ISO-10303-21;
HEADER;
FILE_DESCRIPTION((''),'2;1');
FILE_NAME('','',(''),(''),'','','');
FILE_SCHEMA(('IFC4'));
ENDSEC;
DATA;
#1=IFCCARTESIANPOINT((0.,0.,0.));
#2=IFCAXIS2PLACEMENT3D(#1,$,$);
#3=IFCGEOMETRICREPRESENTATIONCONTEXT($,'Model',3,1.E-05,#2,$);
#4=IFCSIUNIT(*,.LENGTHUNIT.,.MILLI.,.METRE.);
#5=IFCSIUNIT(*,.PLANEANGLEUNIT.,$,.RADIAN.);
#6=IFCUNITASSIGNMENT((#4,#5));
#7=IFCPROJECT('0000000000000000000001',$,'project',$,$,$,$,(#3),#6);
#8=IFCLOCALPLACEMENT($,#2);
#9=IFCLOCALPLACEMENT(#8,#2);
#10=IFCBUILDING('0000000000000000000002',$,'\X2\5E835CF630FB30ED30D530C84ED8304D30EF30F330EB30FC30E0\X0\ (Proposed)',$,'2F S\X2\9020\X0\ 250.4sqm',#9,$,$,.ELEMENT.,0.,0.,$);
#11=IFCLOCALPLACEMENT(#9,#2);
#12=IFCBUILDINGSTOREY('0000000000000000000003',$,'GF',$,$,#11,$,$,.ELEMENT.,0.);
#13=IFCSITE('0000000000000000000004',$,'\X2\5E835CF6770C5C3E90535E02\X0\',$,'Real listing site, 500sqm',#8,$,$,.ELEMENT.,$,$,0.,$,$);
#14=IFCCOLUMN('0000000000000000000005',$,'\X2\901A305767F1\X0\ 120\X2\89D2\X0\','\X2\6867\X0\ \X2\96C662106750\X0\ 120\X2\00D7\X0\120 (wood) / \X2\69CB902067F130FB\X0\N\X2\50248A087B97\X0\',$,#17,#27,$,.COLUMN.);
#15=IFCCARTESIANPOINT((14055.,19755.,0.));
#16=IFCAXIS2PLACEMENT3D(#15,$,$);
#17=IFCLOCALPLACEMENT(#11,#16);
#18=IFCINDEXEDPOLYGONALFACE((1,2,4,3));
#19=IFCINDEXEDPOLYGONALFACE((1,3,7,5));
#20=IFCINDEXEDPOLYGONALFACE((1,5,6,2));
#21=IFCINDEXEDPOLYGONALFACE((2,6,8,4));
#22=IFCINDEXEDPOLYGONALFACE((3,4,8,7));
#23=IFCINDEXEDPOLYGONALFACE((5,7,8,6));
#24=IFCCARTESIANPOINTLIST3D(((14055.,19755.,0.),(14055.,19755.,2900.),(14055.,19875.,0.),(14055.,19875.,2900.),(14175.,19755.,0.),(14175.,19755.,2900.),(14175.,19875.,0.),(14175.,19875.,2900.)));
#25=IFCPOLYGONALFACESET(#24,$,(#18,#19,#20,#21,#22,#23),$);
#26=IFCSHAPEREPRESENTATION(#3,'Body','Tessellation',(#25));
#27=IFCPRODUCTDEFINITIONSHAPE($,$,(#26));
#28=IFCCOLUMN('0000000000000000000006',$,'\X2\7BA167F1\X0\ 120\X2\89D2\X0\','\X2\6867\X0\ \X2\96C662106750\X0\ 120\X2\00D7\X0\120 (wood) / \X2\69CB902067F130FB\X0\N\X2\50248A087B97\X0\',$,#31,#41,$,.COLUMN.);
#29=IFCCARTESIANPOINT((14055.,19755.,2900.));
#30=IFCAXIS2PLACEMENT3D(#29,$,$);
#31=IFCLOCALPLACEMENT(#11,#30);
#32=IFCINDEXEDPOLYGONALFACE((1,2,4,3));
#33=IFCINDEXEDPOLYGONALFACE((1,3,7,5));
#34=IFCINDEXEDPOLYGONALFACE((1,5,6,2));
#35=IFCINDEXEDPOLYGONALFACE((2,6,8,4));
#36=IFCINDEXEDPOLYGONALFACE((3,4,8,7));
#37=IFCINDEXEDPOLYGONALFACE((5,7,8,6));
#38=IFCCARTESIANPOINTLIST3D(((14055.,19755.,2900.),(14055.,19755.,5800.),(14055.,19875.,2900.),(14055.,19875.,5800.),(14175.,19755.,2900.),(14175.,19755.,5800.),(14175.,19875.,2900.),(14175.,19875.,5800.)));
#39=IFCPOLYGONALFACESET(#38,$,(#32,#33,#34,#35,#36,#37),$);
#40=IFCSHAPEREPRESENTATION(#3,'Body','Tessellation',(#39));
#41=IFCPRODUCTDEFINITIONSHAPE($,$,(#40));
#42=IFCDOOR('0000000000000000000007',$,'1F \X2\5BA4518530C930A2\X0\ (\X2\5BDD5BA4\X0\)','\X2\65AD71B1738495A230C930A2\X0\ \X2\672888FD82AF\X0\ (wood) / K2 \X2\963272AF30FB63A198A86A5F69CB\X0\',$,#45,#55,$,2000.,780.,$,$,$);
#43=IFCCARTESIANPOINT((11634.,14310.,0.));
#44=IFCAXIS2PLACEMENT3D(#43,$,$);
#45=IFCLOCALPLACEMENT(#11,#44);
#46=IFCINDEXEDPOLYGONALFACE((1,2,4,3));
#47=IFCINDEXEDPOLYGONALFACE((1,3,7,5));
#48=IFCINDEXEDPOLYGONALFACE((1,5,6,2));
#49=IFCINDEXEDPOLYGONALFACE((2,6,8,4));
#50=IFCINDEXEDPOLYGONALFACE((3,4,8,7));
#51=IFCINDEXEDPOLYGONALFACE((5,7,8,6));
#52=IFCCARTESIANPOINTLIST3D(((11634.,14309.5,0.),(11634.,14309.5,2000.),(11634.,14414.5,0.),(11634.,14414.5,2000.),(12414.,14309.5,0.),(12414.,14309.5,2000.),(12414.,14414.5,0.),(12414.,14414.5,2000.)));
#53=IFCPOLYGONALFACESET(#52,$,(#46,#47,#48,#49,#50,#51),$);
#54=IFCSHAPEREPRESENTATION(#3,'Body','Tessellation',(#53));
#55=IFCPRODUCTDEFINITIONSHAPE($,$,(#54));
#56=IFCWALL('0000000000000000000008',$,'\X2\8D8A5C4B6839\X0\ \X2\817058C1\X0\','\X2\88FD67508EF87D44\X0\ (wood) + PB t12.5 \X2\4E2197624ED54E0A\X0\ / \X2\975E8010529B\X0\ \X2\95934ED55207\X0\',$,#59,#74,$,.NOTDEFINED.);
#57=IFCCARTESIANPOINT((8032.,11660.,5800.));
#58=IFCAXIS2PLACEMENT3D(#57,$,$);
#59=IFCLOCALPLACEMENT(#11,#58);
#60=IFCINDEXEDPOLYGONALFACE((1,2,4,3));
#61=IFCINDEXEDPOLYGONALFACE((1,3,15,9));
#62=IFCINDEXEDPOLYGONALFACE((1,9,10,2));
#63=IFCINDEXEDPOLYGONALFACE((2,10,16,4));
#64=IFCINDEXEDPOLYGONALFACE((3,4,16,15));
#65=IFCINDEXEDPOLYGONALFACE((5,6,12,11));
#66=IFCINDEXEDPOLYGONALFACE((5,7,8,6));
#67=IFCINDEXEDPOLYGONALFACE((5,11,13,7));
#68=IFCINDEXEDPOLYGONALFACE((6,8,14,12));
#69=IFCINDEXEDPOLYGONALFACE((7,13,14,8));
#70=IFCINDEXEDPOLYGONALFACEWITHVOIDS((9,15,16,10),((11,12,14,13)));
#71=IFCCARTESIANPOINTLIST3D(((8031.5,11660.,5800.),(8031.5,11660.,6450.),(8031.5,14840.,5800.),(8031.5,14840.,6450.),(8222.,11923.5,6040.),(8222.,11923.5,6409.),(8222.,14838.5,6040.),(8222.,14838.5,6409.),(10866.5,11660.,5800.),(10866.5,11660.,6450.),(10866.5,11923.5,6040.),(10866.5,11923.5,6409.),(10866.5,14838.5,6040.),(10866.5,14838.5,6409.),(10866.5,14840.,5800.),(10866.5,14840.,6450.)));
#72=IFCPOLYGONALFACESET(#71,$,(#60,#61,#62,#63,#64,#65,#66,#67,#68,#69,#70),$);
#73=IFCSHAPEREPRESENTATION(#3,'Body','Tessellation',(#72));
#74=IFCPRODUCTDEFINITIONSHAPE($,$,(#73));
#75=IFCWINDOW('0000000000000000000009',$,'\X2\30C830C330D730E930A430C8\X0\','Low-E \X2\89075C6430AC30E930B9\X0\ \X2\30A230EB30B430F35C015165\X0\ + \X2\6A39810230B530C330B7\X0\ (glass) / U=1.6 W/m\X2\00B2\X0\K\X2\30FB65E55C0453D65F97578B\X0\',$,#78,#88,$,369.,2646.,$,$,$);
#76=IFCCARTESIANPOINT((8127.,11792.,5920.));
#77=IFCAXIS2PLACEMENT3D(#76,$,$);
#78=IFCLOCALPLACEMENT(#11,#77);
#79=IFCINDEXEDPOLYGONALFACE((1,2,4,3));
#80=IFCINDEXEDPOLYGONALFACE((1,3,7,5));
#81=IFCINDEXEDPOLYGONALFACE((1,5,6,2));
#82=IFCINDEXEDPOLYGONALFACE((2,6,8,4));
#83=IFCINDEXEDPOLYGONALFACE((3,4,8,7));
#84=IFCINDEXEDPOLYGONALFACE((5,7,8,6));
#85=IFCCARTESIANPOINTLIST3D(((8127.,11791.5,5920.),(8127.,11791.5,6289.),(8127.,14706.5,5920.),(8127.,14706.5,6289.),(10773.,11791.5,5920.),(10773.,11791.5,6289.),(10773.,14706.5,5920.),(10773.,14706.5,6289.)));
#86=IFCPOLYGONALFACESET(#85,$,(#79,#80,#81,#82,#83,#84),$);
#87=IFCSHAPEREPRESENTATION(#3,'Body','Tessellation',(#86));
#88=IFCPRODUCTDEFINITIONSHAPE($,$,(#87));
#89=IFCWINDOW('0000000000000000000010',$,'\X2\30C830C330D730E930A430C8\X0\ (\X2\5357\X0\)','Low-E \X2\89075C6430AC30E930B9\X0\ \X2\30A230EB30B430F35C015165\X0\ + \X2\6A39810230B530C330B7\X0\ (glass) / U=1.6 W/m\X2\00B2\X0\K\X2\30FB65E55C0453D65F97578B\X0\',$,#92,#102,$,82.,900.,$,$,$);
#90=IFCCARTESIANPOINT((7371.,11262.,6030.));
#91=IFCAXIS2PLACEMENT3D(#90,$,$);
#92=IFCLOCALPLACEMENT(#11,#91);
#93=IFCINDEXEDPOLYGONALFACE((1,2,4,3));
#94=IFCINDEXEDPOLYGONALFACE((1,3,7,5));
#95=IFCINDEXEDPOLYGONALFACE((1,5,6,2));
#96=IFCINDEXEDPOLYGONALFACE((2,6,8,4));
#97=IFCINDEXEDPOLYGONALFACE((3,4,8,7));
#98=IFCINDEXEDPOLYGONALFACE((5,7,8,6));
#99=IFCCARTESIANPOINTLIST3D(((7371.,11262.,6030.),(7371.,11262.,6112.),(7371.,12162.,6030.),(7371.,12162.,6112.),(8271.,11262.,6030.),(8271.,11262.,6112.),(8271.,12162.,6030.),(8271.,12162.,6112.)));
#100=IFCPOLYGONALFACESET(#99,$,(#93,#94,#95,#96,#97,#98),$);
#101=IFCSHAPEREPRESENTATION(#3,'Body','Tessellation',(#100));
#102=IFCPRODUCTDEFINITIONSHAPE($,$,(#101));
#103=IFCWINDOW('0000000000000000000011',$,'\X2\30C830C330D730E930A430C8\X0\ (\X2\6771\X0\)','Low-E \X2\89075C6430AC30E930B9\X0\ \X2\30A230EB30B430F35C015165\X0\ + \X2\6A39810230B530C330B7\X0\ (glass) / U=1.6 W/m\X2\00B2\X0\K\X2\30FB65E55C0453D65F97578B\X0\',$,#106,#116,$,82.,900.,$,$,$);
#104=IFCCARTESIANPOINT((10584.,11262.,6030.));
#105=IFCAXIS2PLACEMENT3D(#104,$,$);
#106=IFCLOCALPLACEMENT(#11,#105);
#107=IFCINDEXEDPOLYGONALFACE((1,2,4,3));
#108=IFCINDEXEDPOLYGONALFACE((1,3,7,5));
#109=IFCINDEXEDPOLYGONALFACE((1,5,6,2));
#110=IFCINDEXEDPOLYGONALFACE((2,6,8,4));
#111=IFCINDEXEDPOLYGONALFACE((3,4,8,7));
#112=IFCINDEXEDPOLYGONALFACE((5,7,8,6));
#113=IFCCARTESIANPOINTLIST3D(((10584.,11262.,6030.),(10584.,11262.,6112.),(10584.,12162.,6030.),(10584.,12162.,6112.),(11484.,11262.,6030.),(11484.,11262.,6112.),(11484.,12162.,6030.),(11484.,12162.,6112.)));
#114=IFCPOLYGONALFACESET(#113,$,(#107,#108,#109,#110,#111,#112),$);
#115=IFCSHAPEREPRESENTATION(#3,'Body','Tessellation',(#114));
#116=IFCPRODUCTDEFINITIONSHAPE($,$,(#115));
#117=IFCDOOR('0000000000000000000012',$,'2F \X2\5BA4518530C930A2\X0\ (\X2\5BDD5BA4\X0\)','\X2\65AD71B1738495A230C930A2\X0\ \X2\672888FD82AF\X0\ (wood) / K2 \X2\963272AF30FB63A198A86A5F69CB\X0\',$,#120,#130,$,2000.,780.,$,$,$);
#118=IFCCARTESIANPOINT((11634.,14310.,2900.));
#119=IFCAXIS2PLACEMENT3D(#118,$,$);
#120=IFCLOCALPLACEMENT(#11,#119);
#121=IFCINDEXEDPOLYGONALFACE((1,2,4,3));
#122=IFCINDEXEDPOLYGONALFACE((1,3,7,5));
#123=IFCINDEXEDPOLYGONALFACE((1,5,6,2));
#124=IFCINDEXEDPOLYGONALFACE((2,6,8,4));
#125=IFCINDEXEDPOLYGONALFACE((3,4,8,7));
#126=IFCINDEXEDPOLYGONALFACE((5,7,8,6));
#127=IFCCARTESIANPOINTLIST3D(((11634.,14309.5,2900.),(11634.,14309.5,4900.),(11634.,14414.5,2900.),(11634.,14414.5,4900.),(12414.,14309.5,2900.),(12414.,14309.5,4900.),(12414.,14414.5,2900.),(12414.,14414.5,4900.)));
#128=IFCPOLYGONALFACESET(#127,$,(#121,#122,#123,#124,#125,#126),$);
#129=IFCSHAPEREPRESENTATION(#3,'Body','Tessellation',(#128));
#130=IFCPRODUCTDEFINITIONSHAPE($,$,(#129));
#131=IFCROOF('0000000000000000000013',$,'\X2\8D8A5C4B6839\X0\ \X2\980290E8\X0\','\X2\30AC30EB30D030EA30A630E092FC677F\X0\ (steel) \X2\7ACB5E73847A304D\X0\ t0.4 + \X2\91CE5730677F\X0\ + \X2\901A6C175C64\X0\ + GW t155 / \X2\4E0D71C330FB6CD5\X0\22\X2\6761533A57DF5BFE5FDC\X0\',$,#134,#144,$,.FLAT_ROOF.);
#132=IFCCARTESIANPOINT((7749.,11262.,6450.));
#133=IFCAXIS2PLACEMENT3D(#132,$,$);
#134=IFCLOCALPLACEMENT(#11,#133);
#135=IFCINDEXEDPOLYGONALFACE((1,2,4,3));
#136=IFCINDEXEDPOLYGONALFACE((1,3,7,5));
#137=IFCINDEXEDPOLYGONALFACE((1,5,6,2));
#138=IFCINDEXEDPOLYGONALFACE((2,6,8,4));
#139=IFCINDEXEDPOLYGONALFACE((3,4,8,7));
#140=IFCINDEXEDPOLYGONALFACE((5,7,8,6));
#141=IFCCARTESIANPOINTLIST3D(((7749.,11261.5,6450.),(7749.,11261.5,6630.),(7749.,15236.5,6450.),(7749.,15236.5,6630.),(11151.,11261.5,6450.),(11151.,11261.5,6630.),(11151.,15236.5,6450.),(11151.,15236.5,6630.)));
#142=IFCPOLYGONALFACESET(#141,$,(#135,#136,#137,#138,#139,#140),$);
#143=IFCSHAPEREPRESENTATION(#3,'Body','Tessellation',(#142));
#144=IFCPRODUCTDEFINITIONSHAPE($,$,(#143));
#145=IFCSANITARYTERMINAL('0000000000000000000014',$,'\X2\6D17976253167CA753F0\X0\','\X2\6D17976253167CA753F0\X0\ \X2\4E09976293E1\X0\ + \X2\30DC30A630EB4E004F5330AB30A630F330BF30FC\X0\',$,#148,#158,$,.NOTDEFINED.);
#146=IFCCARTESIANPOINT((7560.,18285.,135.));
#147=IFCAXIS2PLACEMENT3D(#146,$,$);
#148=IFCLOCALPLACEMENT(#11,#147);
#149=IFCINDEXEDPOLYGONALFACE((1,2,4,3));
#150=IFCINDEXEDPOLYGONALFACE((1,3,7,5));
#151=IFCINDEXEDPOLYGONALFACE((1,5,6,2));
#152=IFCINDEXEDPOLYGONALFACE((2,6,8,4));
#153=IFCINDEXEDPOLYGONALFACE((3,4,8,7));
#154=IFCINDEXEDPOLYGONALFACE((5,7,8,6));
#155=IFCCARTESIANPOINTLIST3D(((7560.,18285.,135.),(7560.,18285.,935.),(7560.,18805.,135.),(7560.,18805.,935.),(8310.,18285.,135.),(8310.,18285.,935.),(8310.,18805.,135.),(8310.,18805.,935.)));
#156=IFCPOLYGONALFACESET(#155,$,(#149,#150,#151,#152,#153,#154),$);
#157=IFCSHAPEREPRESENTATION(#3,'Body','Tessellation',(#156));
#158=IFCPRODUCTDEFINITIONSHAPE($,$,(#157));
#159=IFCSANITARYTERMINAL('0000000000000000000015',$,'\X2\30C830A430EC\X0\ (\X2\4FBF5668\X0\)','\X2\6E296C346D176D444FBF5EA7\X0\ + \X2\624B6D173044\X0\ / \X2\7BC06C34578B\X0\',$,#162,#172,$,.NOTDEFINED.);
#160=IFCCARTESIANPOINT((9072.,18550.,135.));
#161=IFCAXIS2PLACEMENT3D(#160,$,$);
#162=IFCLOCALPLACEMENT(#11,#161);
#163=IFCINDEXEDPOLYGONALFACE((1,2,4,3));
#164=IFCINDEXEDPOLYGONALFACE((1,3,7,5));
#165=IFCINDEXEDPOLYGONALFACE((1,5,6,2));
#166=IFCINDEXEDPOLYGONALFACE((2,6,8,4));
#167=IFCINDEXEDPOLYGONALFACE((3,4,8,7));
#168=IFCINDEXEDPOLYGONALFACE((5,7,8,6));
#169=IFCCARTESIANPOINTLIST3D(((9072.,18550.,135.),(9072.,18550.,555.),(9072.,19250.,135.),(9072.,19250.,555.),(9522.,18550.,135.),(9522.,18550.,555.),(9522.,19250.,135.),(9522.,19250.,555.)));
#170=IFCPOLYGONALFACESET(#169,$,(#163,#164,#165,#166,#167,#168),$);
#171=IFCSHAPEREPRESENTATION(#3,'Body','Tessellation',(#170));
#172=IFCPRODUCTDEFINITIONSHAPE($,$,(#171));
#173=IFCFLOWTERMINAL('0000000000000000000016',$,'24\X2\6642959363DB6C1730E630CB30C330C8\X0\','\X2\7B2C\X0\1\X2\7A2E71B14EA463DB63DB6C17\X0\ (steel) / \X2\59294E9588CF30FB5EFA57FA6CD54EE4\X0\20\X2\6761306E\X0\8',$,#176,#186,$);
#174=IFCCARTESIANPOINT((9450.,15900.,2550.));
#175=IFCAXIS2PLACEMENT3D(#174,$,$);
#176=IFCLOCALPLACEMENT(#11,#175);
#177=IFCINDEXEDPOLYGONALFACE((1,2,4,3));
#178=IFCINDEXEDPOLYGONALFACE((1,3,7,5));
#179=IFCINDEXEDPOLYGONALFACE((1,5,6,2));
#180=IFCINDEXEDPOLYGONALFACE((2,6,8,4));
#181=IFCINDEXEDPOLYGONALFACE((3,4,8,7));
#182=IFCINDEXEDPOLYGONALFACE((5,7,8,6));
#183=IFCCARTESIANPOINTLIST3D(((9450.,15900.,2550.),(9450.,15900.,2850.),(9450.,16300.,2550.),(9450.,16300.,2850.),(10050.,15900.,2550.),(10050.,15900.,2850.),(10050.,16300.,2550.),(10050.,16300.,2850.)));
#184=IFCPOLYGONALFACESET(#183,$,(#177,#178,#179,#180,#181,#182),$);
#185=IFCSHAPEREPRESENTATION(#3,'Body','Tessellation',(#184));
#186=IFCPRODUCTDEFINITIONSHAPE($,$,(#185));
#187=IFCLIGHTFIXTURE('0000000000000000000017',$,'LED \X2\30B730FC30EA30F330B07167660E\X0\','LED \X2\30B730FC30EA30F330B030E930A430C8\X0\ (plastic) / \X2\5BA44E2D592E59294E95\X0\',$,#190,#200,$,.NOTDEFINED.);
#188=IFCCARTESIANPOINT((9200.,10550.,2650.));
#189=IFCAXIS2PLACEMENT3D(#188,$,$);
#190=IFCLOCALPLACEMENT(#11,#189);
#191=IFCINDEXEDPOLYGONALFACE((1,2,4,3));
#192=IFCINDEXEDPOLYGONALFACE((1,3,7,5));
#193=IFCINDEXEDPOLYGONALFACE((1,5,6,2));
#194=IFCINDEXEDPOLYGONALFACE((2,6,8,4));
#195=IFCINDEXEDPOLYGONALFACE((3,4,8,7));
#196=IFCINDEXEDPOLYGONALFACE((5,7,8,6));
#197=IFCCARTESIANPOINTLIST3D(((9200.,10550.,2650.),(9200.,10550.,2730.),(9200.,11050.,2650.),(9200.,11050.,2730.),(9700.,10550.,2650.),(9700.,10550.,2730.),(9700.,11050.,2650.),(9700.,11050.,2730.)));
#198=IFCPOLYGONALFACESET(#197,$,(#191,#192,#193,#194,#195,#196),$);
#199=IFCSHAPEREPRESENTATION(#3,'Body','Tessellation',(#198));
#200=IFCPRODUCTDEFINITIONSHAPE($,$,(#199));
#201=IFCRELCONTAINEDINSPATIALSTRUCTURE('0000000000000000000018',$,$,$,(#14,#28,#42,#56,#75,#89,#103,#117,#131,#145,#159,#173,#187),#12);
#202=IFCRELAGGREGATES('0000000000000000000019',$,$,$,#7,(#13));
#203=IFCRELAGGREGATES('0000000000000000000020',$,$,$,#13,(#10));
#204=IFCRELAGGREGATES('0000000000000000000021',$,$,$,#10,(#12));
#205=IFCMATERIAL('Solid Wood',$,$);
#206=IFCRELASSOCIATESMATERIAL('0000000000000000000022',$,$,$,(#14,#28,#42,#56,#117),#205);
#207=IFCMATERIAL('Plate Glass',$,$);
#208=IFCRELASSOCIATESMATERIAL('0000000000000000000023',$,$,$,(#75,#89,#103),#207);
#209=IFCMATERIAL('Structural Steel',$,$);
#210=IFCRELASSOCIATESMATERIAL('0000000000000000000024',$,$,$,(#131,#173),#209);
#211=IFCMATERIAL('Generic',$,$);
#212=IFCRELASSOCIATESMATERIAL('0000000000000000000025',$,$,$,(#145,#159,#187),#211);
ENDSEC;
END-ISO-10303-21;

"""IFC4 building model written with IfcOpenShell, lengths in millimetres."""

from ifc_helpers import new_model, si_unit, frame, frame_2d, origin, place, context, project, spatial, rectangle, extrude, material, element, fill, save


model = new_model("IFC4")

# Units and contexts
model_context = context("Model", 3, precision=1e-05, world=origin())
ifc_project = project(units=[si_unit("LENGTHUNIT", "METRE", prefix="MILLI"), si_unit("PLANEANGLEUNIT", "RADIAN")], contexts=[model_context])

# Site, building, storey
site_placement = place(None, origin())
site = spatial("IfcSite", under=ifc_project, at=site_placement, Name="広島県尾道市", ObjectType="Real listing site, 500sqm", CompositionType="ELEMENT", RefElevation=0.0)
building_placement = place(site_placement, origin())
building = spatial("IfcBuilding", under=site, at=building_placement, Name="広島・ロフト付きワンルーム (Proposed)", ObjectType="2F S造 250.4sqm", CompositionType="ELEMENT", ElevationOfRefHeight=0.0, ElevationOfTerrain=0.0)
storey_placement = place(building_placement, origin())
storey = spatial("IfcBuildingStorey", under=building, at=storey_placement, Name="GF", CompositionType="ELEMENT", Elevation=0.0)

# Columns
ifc_material_1 = material(Name="Solid Wood")
column_1_placement = place(storey_placement, frame((14055.0, 19755.0, 0.0)))
element("IfcColumn", 1, at=column_1_placement, inside=storey, material=ifc_material_1, Name="通し柱 120角", Description="桧 集成材 120×120 (wood) / 構造柱・N値計算", PredefinedType="COLUMN", context=model_context, shape_type="SweptSolid", body=[
    extrude(rectangle(XDim=120.0, YDim=120.0, at=frame_2d((60.0, 60.0))), frame((14055.0, 19755.0, 0.0)), (0.0, 0.0, 1.0), 2900.0),
])
column_2_placement = place(storey_placement, frame((14055.0, 19755.0, 2900.0)))
element("IfcColumn", 2, at=column_2_placement, inside=storey, material=ifc_material_1, Name="管柱 120角", Description="桧 集成材 120×120 (wood) / 構造柱・N値計算", PredefinedType="COLUMN", context=model_context, shape_type="SweptSolid", body=[
    extrude(rectangle(XDim=120.0, YDim=120.0, at=frame_2d((60.0, 60.0))), frame((14055.0, 19755.0, 2900.0)), (0.0, 0.0, 1.0), 2900.0),
])

# Door
door_1_placement = place(storey_placement, frame((11634.0, 14310.0, 0.0)))
element("IfcDoor", 3, at=door_1_placement, inside=storey, material=ifc_material_1, Name="1F 室内ドア (寝室)", Description="断熱玄関ドア 木製芯 (wood) / K2 防犯・採風機構", OverallHeight=2000.0, OverallWidth=780.0, context=model_context, shape_type="SweptSolid", body=[
    extrude(rectangle(XDim=780.0, YDim=105.0, at=frame_2d((390.0, 52.0))), frame((11634.0, 14310.0, 0.0)), (0.0, 0.0, 1.0), 2000.0),
])

# Wall, openings, windows
wall_1_placement = place(storey_placement, frame((8032.0, 11660.0, 5800.0)))
wall_1 = element("IfcWall", 4, at=wall_1_placement, inside=storey, material=ifc_material_1, Name="越屋根 腰壁", Description="製材軸組 (wood) + PB t12.5 両面仕上 / 非耐力 間仕切", PredefinedType="NOTDEFINED", context=model_context, shape_type="SweptSolid", body=[
    extrude(rectangle(XDim=2835.0, YDim=3180.0, at=frame_2d((1417.0, 1590.0))), frame((8032.0, 11660.0, 5800.0)), (0.0, 0.0, 1.0), 650.0),
])
opening_1_placement = place(storey_placement, frame((8127.0, 11792.0, 5920.0)))
opening_1 = element("IfcOpeningElement", 5, at=opening_1_placement, cuts=wall_1, PredefinedType="NOTDEFINED", context=model_context, shape_type="SweptSolid", body=[
    extrude(rectangle(XDim=2646.0, YDim=2915.0, at=frame_2d((1323.0, 1457.0))), frame((8127.0, 11792.0, 5920.0)), (0.0, 0.0, 1.0), 369.0),
])
opening_2_placement = place(storey_placement, frame((7371.0, 11262.0, 6030.0)))
opening_2 = element("IfcOpeningElement", 6, at=opening_2_placement, cuts=wall_1, PredefinedType="NOTDEFINED", context=model_context, shape_type="SweptSolid", body=[
    extrude(rectangle(XDim=900.0, YDim=900.0, at=frame_2d((450.0, 450.0))), frame((7371.0, 11262.0, 6030.0)), (0.0, 0.0, 1.0), 82.0),
])
opening_3_placement = place(storey_placement, frame((10584.0, 11262.0, 6030.0)))
opening_3 = element("IfcOpeningElement", 7, at=opening_3_placement, cuts=wall_1, PredefinedType="NOTDEFINED", context=model_context, shape_type="SweptSolid", body=[
    extrude(rectangle(XDim=900.0, YDim=900.0, at=frame_2d((450.0, 450.0))), frame((10584.0, 11262.0, 6030.0)), (0.0, 0.0, 1.0), 82.0),
])
ifc_material_2 = material(Name="Plate Glass")
window_1_placement = place(storey_placement, frame((8127.0, 11792.0, 5920.0)))
window_1 = element("IfcWindow", 8, at=window_1_placement, inside=storey, material=ifc_material_2, Name="トップライト", Description="Low-E 複層ガラス アルゴン封入 + 樹脂サッシ (glass) / U=1.6 W/m²K・日射取得型", OverallHeight=369.0, OverallWidth=2646.0, context=model_context, shape_type="SweptSolid", body=[
    extrude(rectangle(XDim=2646.0, YDim=2915.0, at=frame_2d((1323.0, 1457.0))), frame((8127.0, 11792.0, 5920.0)), (0.0, 0.0, 1.0), 369.0),
])
fill(opening_1, window_1)
window_2_placement = place(storey_placement, frame((7371.0, 11262.0, 6030.0)))
window_2 = element("IfcWindow", 9, at=window_2_placement, inside=storey, material=ifc_material_2, Name="トップライト (南)", Description="Low-E 複層ガラス アルゴン封入 + 樹脂サッシ (glass) / U=1.6 W/m²K・日射取得型", OverallHeight=82.0, OverallWidth=900.0, context=model_context, shape_type="SweptSolid", body=[
    extrude(rectangle(XDim=900.0, YDim=900.0, at=frame_2d((450.0, 450.0))), frame((7371.0, 11262.0, 6030.0)), (0.0, 0.0, 1.0), 82.0),
])
fill(opening_2, window_2)
window_3_placement = place(storey_placement, frame((10584.0, 11262.0, 6030.0)))
window_3 = element("IfcWindow", 10, at=window_3_placement, inside=storey, material=ifc_material_2, Name="トップライト (東)", Description="Low-E 複層ガラス アルゴン封入 + 樹脂サッシ (glass) / U=1.6 W/m²K・日射取得型", OverallHeight=82.0, OverallWidth=900.0, context=model_context, shape_type="SweptSolid", body=[
    extrude(rectangle(XDim=900.0, YDim=900.0, at=frame_2d((450.0, 450.0))), frame((10584.0, 11262.0, 6030.0)), (0.0, 0.0, 1.0), 82.0),
])
fill(opening_3, window_3)

# Door
door_2_placement = place(storey_placement, frame((11634.0, 14310.0, 2900.0)))
element("IfcDoor", 11, at=door_2_placement, inside=storey, material=ifc_material_1, Name="2F 室内ドア (寝室)", Description="断熱玄関ドア 木製芯 (wood) / K2 防犯・採風機構", OverallHeight=2000.0, OverallWidth=780.0, context=model_context, shape_type="SweptSolid", body=[
    extrude(rectangle(XDim=780.0, YDim=105.0, at=frame_2d((390.0, 52.0))), frame((11634.0, 14310.0, 2900.0)), (0.0, 0.0, 1.0), 2000.0),
])

# Roof
ifc_material_3 = material(Name="Structural Steel")
roof_placement = place(storey_placement, frame((7749.0, 11262.0, 6450.0)))
element("IfcRoof", 12, at=roof_placement, inside=storey, material=ifc_material_3, Name="越屋根 頂部", Description="ガルバリウム鋼板 (steel) 立平葺き t0.4 + 野地板 + 通気層 + GW t155 / 不燃・法22条区域対応", PredefinedType="FLAT_ROOF", context=model_context, shape_type="SweptSolid", body=[
    extrude(rectangle(XDim=3402.0, YDim=3975.0, at=frame_2d((1701.0, 1987.0))), frame((7749.0, 11262.0, 6450.0)), (0.0, 0.0, 1.0), 180.0),
])

# Sanitary terminals
ifc_material_4 = material(Name="Generic")
sanitary_terminal_1_placement = place(storey_placement, frame((7560.0, 18285.0, 135.0)))
element("IfcSanitaryTerminal", 13, at=sanitary_terminal_1_placement, inside=storey, material=ifc_material_4, Name="洗面化粧台", Description="洗面化粧台 三面鏡 + ボウル一体カウンター", PredefinedType="NOTDEFINED", context=model_context, shape_type="SweptSolid", body=[
    extrude(rectangle(XDim=750.0, YDim=520.0, at=frame_2d((375.0, 260.0))), frame((7560.0, 18285.0, 135.0)), (0.0, 0.0, 1.0), 800.0),
])
sanitary_terminal_2_placement = place(storey_placement, frame((9072.0, 18550.0, 135.0)))
element("IfcSanitaryTerminal", 14, at=sanitary_terminal_2_placement, inside=storey, material=ifc_material_4, Name="トイレ (便器)", Description="温水洗浄便座 + 手洗い / 節水型", PredefinedType="NOTDEFINED", context=model_context, shape_type="SweptSolid", body=[
    extrude(rectangle(XDim=450.0, YDim=700.0, at=frame_2d((225.0, 350.0))), frame((9072.0, 18550.0, 135.0)), (0.0, 0.0, 1.0), 420.0),
])

# Flow terminal
flow_terminal_placement = place(storey_placement, frame((9450.0, 15900.0, 2550.0)))
element("IfcFlowTerminal", 15, at=flow_terminal_placement, inside=storey, material=ifc_material_3, Name="24時間換気ユニット", Description="第1種熱交換換気 (steel) / 天井裏・建基法令20条の8", context=model_context, shape_type="SweptSolid", body=[
    extrude(rectangle(XDim=600.0, YDim=400.0, at=frame_2d((300.0, 200.0))), frame((9450.0, 15900.0, 2550.0)), (0.0, 0.0, 1.0), 300.0),
])

# Light fixture
light_fixture_1_placement = place(storey_placement, frame((9200.0, 10550.0, 2650.0)))
element("IfcLightFixture", 16, at=light_fixture_1_placement, inside=storey, material=ifc_material_4, Name="LED シーリング照明", Description="LED シーリングライト (plastic) / 室中央天井", PredefinedType="NOTDEFINED", context=model_context, shape_type="SweptSolid", body=[
    extrude(rectangle(XDim=500.0, YDim=500.0, at=frame_2d((250.0, 250.0))), frame((9200.0, 10550.0, 2650.0)), (0.0, 0.0, 1.0), 80.0),
])

save(model, "model.ifc")
